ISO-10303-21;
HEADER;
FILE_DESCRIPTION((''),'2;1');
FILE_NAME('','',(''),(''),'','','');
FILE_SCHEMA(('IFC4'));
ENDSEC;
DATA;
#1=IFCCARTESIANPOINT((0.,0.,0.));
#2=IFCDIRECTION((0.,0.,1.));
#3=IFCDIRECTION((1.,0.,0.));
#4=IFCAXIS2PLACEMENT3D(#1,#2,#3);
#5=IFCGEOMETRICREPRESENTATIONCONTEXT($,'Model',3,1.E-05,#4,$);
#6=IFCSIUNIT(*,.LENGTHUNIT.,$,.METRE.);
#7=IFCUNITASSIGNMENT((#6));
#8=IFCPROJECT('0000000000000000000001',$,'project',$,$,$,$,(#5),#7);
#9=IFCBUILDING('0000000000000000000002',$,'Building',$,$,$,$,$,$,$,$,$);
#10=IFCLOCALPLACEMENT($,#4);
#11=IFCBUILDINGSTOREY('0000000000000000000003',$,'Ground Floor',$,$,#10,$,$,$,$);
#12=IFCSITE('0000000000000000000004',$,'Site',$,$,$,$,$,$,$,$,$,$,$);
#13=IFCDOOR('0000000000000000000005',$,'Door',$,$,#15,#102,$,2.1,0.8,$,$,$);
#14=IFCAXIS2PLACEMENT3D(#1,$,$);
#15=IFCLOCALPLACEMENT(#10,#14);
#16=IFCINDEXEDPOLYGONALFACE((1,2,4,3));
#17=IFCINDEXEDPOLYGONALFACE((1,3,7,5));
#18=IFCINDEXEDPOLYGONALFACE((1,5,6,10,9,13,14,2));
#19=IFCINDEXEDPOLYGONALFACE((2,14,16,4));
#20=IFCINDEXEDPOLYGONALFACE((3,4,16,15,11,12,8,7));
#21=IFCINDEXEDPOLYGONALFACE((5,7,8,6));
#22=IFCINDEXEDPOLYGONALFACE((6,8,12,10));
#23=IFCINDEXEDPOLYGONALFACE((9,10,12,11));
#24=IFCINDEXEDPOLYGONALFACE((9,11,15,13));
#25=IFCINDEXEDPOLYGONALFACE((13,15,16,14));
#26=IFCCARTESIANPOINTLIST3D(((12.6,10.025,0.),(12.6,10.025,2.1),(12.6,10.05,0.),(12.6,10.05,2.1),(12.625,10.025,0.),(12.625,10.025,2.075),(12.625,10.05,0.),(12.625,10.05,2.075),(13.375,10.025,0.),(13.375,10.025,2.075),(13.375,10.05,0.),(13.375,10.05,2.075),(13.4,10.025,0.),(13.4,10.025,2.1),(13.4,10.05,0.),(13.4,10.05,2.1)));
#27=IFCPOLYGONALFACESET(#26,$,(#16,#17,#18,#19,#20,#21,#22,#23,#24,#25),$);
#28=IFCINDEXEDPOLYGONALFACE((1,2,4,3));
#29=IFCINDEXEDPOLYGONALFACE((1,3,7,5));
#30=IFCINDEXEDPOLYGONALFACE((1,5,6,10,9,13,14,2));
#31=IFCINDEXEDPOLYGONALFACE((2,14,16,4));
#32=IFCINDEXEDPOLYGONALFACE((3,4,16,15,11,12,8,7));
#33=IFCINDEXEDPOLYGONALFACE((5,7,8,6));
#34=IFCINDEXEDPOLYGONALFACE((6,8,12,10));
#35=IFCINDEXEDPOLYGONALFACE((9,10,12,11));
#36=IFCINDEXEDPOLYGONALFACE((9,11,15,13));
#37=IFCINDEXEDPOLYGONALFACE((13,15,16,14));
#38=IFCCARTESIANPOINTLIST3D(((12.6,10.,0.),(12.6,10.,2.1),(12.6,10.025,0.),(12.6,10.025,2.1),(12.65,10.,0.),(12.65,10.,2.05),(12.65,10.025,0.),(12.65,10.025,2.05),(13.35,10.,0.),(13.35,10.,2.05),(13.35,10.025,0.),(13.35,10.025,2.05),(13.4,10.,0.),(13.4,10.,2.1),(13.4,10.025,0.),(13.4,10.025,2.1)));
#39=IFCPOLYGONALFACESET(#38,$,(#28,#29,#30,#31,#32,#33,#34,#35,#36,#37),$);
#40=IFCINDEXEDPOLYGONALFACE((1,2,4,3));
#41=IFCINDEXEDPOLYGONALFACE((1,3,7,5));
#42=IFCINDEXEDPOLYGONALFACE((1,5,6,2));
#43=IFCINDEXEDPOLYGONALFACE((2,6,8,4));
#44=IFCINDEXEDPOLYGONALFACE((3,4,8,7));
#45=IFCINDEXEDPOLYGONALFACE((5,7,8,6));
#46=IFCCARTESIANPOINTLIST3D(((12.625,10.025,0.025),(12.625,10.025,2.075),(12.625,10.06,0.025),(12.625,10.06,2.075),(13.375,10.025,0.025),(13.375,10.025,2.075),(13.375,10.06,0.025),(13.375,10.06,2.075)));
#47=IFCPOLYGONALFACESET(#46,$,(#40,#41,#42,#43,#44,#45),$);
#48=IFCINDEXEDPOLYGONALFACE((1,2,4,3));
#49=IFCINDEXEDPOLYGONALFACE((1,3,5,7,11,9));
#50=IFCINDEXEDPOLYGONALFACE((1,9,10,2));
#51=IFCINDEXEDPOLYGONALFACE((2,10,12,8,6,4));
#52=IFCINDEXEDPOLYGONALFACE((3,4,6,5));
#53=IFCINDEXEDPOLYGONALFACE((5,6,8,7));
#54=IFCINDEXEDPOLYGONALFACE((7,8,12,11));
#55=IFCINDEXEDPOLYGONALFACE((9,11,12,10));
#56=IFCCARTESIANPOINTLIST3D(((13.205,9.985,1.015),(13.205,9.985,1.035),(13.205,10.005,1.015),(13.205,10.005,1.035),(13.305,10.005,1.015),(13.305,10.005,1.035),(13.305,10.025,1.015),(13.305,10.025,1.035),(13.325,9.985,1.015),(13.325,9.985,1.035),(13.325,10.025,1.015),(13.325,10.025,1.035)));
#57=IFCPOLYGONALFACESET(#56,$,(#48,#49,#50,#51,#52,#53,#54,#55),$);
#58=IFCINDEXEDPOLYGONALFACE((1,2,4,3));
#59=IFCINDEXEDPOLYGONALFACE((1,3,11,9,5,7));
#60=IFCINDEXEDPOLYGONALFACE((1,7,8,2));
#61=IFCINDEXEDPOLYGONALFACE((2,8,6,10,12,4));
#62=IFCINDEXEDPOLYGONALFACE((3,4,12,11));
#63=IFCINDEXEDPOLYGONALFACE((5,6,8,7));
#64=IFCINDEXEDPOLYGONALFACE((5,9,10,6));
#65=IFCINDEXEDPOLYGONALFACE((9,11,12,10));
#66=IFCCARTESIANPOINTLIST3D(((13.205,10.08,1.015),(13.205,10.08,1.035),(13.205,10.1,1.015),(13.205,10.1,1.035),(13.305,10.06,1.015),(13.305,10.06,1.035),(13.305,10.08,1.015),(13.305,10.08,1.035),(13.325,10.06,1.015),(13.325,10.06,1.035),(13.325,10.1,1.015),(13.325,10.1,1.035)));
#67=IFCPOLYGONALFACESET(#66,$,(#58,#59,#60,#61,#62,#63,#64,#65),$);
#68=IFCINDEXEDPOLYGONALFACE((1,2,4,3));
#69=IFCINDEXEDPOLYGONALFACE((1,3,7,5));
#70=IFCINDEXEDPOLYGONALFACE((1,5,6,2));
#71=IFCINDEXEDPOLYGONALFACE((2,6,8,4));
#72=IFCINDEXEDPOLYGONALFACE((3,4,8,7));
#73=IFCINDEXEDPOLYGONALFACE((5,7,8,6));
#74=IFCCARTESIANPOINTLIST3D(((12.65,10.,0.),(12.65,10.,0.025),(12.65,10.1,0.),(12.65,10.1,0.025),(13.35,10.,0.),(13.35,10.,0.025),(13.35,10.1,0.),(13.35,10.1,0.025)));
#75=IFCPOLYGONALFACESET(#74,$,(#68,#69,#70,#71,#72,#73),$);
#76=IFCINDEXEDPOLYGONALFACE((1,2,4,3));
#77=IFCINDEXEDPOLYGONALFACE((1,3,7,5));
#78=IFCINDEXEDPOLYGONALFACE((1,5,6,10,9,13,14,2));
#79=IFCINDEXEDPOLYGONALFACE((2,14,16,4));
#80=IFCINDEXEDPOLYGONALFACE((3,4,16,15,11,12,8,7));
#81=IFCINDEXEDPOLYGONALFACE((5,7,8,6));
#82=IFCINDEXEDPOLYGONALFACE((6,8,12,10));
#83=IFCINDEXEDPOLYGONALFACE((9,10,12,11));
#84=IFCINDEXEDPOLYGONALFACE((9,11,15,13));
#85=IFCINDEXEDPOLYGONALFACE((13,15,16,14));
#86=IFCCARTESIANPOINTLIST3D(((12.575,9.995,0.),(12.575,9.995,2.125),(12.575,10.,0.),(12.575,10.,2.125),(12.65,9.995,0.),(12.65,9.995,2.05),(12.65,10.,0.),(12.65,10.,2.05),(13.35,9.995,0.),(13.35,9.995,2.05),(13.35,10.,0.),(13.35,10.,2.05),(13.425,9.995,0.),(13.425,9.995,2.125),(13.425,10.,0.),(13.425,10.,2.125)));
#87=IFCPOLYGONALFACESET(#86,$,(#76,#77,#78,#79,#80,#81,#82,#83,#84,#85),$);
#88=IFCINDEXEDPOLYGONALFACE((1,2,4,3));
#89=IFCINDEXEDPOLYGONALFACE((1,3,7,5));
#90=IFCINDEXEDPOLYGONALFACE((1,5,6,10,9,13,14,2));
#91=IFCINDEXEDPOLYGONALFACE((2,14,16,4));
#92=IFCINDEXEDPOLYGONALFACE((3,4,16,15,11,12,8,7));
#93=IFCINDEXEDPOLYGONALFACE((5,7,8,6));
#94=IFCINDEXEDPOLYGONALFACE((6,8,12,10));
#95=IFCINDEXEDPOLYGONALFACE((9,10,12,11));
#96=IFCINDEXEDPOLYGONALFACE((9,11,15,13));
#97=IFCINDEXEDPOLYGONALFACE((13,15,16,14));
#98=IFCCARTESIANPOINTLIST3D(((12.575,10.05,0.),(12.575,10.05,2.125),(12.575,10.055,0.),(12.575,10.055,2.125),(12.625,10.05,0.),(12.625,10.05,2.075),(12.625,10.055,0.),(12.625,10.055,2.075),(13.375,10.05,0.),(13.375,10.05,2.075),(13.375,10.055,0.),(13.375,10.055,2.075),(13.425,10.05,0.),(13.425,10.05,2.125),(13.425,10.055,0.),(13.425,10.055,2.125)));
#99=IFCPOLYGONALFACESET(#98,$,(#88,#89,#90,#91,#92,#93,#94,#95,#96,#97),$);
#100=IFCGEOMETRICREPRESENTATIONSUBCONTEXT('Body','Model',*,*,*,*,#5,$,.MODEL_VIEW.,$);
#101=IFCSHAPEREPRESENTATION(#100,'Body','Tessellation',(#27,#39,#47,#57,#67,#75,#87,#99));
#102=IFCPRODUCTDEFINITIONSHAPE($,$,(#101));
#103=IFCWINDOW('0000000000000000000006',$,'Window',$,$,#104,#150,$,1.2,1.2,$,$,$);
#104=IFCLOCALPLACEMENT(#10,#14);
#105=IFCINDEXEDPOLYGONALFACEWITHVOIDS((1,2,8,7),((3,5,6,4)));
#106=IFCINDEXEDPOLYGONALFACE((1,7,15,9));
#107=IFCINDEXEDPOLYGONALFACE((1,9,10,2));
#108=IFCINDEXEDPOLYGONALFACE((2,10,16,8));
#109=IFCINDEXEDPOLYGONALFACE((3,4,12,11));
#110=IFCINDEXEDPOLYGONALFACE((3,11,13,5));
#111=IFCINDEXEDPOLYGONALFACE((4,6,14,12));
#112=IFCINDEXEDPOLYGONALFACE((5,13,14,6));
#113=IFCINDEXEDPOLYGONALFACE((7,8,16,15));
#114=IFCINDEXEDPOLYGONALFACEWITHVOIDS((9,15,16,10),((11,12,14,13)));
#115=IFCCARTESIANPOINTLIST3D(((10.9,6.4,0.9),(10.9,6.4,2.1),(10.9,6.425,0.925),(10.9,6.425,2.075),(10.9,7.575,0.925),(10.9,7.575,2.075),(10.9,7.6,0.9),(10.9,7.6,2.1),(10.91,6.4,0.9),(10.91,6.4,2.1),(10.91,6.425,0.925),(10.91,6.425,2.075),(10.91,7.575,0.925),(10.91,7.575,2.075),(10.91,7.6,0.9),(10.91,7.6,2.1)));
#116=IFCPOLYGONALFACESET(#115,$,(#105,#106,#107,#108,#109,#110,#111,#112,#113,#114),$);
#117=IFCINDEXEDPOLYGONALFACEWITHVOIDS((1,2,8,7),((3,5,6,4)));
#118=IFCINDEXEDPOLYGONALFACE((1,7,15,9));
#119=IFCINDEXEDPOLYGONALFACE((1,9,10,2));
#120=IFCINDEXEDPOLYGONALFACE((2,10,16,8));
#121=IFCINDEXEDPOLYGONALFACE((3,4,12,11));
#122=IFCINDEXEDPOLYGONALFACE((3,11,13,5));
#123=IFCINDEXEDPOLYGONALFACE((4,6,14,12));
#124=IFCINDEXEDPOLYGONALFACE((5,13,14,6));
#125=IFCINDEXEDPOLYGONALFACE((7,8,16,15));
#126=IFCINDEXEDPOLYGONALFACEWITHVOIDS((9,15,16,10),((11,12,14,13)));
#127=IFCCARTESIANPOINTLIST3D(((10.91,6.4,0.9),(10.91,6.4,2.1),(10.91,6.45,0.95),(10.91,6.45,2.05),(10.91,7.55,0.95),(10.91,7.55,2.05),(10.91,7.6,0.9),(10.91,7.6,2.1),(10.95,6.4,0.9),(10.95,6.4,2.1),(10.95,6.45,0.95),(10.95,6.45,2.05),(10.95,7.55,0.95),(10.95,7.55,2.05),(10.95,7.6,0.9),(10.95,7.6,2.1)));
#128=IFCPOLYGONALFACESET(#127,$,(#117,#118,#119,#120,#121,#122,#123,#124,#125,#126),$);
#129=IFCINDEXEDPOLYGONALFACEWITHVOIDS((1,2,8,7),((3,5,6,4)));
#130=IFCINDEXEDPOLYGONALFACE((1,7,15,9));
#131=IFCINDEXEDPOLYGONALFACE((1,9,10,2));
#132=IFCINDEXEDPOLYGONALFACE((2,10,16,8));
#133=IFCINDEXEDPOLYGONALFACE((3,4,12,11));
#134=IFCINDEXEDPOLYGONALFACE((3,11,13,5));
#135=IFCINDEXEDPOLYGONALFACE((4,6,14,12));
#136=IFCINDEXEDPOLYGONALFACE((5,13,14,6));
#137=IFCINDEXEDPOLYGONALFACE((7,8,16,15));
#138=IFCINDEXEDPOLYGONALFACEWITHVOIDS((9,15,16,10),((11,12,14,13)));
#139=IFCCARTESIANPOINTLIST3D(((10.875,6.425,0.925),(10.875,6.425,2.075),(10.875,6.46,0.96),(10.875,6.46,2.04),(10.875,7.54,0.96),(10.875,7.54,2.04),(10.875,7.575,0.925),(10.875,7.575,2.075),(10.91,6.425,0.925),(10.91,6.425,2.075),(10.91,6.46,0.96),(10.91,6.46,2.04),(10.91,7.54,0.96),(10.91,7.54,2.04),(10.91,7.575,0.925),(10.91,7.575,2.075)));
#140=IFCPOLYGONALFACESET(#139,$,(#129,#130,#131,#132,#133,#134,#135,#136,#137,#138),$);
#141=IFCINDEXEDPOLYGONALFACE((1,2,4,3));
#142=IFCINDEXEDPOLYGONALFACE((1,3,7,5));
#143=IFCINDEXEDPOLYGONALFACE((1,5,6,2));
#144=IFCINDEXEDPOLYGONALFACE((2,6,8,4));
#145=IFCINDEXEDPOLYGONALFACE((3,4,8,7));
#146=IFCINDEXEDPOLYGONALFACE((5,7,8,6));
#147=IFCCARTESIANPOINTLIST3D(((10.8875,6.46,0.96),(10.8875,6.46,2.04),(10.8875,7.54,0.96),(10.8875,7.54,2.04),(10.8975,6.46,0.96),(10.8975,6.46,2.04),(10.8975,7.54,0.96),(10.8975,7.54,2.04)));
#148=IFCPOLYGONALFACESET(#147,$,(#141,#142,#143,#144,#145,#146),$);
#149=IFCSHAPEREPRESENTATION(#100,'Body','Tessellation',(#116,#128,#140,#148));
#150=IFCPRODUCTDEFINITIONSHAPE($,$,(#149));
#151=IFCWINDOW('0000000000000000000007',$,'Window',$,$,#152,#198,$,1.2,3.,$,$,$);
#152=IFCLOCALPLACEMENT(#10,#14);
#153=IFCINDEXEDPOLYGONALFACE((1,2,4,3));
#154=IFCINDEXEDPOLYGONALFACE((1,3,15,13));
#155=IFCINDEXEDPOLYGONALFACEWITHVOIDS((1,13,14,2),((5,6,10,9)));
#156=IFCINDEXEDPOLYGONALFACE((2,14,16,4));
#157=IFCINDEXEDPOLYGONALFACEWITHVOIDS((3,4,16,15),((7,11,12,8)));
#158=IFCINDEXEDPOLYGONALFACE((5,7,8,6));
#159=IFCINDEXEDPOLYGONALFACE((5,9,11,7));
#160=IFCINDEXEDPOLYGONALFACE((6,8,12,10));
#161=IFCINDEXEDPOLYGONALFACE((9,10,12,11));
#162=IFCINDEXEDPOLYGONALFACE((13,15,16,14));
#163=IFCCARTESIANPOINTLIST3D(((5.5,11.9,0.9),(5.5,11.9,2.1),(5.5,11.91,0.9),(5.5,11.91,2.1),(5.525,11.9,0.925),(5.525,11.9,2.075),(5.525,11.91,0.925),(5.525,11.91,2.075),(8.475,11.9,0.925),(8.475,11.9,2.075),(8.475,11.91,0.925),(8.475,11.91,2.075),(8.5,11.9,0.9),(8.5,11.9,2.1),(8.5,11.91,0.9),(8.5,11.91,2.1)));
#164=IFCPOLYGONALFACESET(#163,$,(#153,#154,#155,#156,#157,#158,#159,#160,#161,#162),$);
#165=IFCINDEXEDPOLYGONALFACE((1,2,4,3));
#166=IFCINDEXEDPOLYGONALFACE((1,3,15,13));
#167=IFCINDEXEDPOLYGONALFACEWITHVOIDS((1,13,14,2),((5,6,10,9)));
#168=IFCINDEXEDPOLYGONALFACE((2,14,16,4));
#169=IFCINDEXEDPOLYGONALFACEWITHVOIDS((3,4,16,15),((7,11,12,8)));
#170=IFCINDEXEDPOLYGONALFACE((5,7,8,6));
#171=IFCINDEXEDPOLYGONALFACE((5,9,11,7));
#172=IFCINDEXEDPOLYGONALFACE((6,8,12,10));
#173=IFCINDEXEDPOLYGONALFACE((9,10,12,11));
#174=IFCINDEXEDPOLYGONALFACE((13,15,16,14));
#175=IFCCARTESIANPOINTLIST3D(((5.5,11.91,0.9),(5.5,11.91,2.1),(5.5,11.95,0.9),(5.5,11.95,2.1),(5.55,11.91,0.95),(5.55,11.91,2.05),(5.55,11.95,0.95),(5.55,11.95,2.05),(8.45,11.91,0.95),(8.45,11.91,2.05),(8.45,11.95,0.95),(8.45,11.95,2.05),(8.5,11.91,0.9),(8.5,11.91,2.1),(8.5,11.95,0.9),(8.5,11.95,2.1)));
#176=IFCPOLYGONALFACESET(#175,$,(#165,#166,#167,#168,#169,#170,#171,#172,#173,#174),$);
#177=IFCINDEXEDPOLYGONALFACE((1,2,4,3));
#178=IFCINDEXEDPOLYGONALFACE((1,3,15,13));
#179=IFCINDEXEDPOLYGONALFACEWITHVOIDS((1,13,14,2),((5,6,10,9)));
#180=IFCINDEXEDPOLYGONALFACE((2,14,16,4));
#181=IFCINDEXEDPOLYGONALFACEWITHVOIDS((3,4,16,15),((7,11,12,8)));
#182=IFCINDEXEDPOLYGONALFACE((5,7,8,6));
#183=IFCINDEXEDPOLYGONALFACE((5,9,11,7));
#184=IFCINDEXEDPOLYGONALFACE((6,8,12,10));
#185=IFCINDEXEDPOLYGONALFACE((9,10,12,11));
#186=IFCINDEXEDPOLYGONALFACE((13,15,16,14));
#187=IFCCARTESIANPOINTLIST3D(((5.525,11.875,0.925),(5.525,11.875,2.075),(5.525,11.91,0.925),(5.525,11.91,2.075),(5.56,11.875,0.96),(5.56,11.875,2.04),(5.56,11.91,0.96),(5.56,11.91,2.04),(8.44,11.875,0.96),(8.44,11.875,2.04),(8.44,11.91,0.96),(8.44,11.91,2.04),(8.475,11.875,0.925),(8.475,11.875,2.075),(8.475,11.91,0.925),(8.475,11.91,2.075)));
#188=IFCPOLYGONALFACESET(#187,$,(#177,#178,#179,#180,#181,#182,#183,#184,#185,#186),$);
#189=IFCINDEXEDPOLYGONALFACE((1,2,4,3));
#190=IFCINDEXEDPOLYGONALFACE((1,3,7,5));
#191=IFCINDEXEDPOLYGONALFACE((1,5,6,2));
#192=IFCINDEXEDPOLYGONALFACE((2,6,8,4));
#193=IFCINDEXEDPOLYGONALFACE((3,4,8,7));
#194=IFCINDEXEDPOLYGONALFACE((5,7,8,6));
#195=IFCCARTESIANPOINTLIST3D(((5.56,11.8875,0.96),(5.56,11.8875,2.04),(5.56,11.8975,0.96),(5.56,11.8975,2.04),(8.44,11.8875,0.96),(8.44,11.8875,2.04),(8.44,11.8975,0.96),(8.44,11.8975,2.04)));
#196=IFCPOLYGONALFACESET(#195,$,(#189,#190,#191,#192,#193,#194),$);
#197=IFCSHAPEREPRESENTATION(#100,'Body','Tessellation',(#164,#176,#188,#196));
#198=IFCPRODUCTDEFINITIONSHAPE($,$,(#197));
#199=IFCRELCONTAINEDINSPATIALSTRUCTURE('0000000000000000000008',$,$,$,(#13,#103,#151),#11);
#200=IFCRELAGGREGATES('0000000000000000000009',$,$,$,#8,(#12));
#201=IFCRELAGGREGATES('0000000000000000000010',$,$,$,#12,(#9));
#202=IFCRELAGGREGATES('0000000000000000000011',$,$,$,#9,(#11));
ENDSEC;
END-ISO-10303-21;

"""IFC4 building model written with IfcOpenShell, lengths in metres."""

from ifc_helpers import new_model, si_unit, frame, origin_with_axes, place, context, subcontext, project, spatial, line, indexed_curve, outline, extrude, element, save


model = new_model("IFC4")

# Units and contexts
model_context = context("Model", 3, precision=1e-05, world=origin_with_axes())
body_context = subcontext(model_context, "Body", "Model", "MODEL_VIEW")
ifc_project = project(units=[si_unit("LENGTHUNIT", "METRE")], contexts=[model_context])

# Site, building, storey
site = spatial("IfcSite", under=ifc_project, Name="Site")
building = spatial("IfcBuilding", under=site, Name="Building")
storey_placement = place(None, origin_with_axes())
storey = spatial("IfcBuildingStorey", under=building, at=storey_placement, Name="Ground Floor")

# Door
door_1_placement = place(storey_placement, frame((12.6, 10.0, 0.0), z_axis=(0.0, 0.0, 1.0), x_axis=(1.0, 0.0, 0.0)))
element("IfcDoor", 1, at=door_1_placement, inside=storey, Name="Door", OverallHeight=2.1, OverallWidth=0.8, context=body_context, shape_type="SweptSolid", body=[
    extrude(outline(indexed_curve([(0.0, 0.0), (0.0, 2.1), (0.8, 2.1), (0.8, 0.0), (0.775, 0.0), (0.775, 2.075), (0.025, 2.075), (0.025, 0.0)], segments=[line(1, 2, 3, 4, 5, 6, 7, 8, 1)])), frame((0.0, 0.025, 0.0), z_axis=(0.0, -1.0, 0.0), x_axis=(1.0, 0.0, 0.0)), (0.0, 0.0, -1.0), 0.025),
    extrude(outline(indexed_curve([(0.0, 0.0), (0.0, 2.1), (0.8, 2.1), (0.8, 0.0), (0.75, 0.0), (0.75, 2.05), (0.05, 2.05), (0.05, 0.0)], segments=[line(1, 2, 3, 4, 5, 6, 7, 8, 1)])), frame((0.0, 0.0, 0.0), z_axis=(0.0, -1.0, 0.0), x_axis=(1.0, 0.0, 0.0)), (0.0, 0.0, -1.0), 0.025),
    extrude(outline(indexed_curve([(0.0, 0.0), (0.75, 0.0), (0.75, 0.035), (0.0, 0.035)], segments=[line(1, 2, 3, 4, 1)])), frame((0.025, 0.025, 0.025), z_axis=(0.0, 0.0, 1.0), x_axis=(1.0, 0.0, 0.0)), (0.0, 0.0, 1.0), 2.05),
    extrude(outline(indexed_curve([(0.0, 0.0), (0.0, -0.04), (-0.12, -0.04), (-0.12, -0.02), (-0.02, -0.02), (-0.02, 0.0)], segments=[line(1, 2, 3, 4, 5, 6, 1)])), frame((0.725, 0.025, 1.015), z_axis=(0.0, 0.0, 1.0), x_axis=(1.0, 0.0, 0.0)), (0.0, 0.0, 1.0), 0.02),
    extrude(outline(indexed_curve([(0.0, 0.0), (0.0, 0.04), (-0.12, 0.04), (-0.12, 0.02), (-0.02, 0.02), (-0.02, 0.0)], segments=[line(1, 2, 3, 4, 5, 6, 1)])), frame((0.725, 0.06, 1.015), z_axis=(0.0, 0.0, 1.0), x_axis=(1.0, 0.0, 0.0)), (0.0, 0.0, 1.0), 0.02),
    extrude(outline(indexed_curve([(0.0, 0.0), (0.7, 0.0), (0.7, 0.1), (0.0, 0.1)], segments=[line(1, 2, 3, 4, 1)])), frame((0.05, 0.0, 0.0), z_axis=(0.0, 0.0, 1.0), x_axis=(1.0, 0.0, 0.0)), (0.0, 0.0, 1.0), 0.025),
    extrude(outline(indexed_curve([(0.0, 0.0), (0.0, 2.125), (0.85, 2.125), (0.85, 0.0), (0.775, 0.0), (0.775, 2.05), (0.075, 2.05), (0.075, 0.0)], segments=[line(1, 2, 3, 4, 5, 6, 7, 8, 1)])), frame((-0.025, -0.005, 0.0), z_axis=(0.0, -1.0, 0.0), x_axis=(1.0, 0.0, 0.0)), (0.0, 0.0, -1.0), 0.005),
    extrude(outline(indexed_curve([(0.0, 0.0), (0.0, 2.125), (0.85, 2.125), (0.85, 0.0), (0.8, 0.0), (0.8, 2.075), (0.05, 2.075), (0.05, 0.0)], segments=[line(1, 2, 3, 4, 5, 6, 7, 8, 1)])), frame((-0.025, 0.05, 0.0), z_axis=(0.0, -1.0, 0.0), x_axis=(1.0, 0.0, 0.0)), (0.0, 0.0, -1.0), 0.005),
])

# Windows
window_1_placement = place(storey_placement, frame((11.0, 6.4, 0.9), z_axis=(0.0, 0.0, 1.0), x_axis=(0.0, 1.0, 0.0)))
element("IfcWindow", 2, at=window_1_placement, inside=storey, Name="Window", OverallHeight=1.2, OverallWidth=1.2, context=body_context, shape_type="SweptSolid", body=[
    extrude(outline(indexed_curve([(0.0, 0.0), (1.2, 0.0), (1.2, 1.2), (0.0, 1.2)], segments=[line(1, 2, 3, 4, 1)]), holes=[indexed_curve([(0.025, 0.025), (1.175, 0.025), (1.175, 1.175), (0.025, 1.175)], segments=[line(1, 2, 3, 4, 1)])]), frame((0.0, 0.09, 0.0), z_axis=(0.0, -1.0, 0.0), x_axis=(1.0, 0.0, 0.0)), (0.0, 0.0, -1.0), 0.01),
    extrude(outline(indexed_curve([(0.0, 0.0), (1.2, 0.0), (1.2, 1.2), (0.0, 1.2)], segments=[line(1, 2, 3, 4, 1)]), holes=[indexed_curve([(0.05, 0.05), (1.15, 0.05), (1.15, 1.15), (0.05, 1.15)], segments=[line(1, 2, 3, 4, 1)])]), frame((0.0, 0.05, 0.0), z_axis=(0.0, -1.0, 0.0), x_axis=(1.0, 0.0, 0.0)), (0.0, 0.0, -1.0), 0.04),
    extrude(outline(indexed_curve([(0.0, 0.0), (1.15, 0.0), (1.15, 1.15), (0.0, 1.15)], segments=[line(1, 2, 3, 4, 1)]), holes=[indexed_curve([(0.035, 0.035), (1.115, 0.035), (1.115, 1.115), (0.035, 1.115)], segments=[line(1, 2, 3, 4, 1)])]), frame((0.025, 0.09, 0.025), z_axis=(0.0, -1.0, 0.0), x_axis=(1.0, 0.0, 0.0)), (0.0, 0.0, -1.0), 0.035),
    extrude(outline(indexed_curve([(0.035, 0.035), (1.115, 0.035), (1.115, 1.115), (0.035, 1.115)], segments=[line(1, 2, 3, 4, 1)])), frame((0.025, 0.1025, 0.025), z_axis=(0.0, -1.0, 0.0), x_axis=(1.0, 0.0, 0.0)), (0.0, 0.0, -1.0), 0.01),
])
window_2_placement = place(storey_placement, frame((8.5, 12.0, 0.9), z_axis=(0.0, 0.0, 1.0), x_axis=(-1.0, 0.0, 0.0)))
element("IfcWindow", 3, at=window_2_placement, inside=storey, Name="Window", OverallHeight=1.2, OverallWidth=3.0, context=body_context, shape_type="SweptSolid", body=[
    extrude(outline(indexed_curve([(0.0, 0.0), (3.0, 0.0), (3.0, 1.2), (0.0, 1.2)], segments=[line(1, 2, 3, 4, 1)]), holes=[indexed_curve([(0.025, 0.025), (2.975, 0.025), (2.975, 1.175), (0.025, 1.175)], segments=[line(1, 2, 3, 4, 1)])]), frame((0.0, 0.09, 0.0), z_axis=(0.0, -1.0, 0.0), x_axis=(1.0, 0.0, 0.0)), (0.0, 0.0, -1.0), 0.01),
    extrude(outline(indexed_curve([(0.0, 0.0), (3.0, 0.0), (3.0, 1.2), (0.0, 1.2)], segments=[line(1, 2, 3, 4, 1)]), holes=[indexed_curve([(0.05, 0.05), (2.95, 0.05), (2.95, 1.15), (0.05, 1.15)], segments=[line(1, 2, 3, 4, 1)])]), frame((0.0, 0.05, 0.0), z_axis=(0.0, -1.0, 0.0), x_axis=(1.0, 0.0, 0.0)), (0.0, 0.0, -1.0), 0.04),
    extrude(outline(indexed_curve([(0.0, 0.0), (2.95, 0.0), (2.95, 1.15), (0.0, 1.15)], segments=[line(1, 2, 3, 4, 1)]), holes=[indexed_curve([(0.035, 0.035), (2.915, 0.035), (2.915, 1.115), (0.035, 1.115)], segments=[line(1, 2, 3, 4, 1)])]), frame((0.025, 0.09, 0.025), z_axis=(0.0, -1.0, 0.0), x_axis=(1.0, 0.0, 0.0)), (0.0, 0.0, -1.0), 0.035),
    extrude(outline(indexed_curve([(0.035, 0.035), (2.915, 0.035), (2.915, 1.115), (0.035, 1.115)], segments=[line(1, 2, 3, 4, 1)])), frame((0.025, 0.1025, 0.025), z_axis=(0.0, -1.0, 0.0), x_axis=(1.0, 0.0, 0.0)), (0.0, 0.0, -1.0), 0.01),
])

save(model, "model.ifc")
